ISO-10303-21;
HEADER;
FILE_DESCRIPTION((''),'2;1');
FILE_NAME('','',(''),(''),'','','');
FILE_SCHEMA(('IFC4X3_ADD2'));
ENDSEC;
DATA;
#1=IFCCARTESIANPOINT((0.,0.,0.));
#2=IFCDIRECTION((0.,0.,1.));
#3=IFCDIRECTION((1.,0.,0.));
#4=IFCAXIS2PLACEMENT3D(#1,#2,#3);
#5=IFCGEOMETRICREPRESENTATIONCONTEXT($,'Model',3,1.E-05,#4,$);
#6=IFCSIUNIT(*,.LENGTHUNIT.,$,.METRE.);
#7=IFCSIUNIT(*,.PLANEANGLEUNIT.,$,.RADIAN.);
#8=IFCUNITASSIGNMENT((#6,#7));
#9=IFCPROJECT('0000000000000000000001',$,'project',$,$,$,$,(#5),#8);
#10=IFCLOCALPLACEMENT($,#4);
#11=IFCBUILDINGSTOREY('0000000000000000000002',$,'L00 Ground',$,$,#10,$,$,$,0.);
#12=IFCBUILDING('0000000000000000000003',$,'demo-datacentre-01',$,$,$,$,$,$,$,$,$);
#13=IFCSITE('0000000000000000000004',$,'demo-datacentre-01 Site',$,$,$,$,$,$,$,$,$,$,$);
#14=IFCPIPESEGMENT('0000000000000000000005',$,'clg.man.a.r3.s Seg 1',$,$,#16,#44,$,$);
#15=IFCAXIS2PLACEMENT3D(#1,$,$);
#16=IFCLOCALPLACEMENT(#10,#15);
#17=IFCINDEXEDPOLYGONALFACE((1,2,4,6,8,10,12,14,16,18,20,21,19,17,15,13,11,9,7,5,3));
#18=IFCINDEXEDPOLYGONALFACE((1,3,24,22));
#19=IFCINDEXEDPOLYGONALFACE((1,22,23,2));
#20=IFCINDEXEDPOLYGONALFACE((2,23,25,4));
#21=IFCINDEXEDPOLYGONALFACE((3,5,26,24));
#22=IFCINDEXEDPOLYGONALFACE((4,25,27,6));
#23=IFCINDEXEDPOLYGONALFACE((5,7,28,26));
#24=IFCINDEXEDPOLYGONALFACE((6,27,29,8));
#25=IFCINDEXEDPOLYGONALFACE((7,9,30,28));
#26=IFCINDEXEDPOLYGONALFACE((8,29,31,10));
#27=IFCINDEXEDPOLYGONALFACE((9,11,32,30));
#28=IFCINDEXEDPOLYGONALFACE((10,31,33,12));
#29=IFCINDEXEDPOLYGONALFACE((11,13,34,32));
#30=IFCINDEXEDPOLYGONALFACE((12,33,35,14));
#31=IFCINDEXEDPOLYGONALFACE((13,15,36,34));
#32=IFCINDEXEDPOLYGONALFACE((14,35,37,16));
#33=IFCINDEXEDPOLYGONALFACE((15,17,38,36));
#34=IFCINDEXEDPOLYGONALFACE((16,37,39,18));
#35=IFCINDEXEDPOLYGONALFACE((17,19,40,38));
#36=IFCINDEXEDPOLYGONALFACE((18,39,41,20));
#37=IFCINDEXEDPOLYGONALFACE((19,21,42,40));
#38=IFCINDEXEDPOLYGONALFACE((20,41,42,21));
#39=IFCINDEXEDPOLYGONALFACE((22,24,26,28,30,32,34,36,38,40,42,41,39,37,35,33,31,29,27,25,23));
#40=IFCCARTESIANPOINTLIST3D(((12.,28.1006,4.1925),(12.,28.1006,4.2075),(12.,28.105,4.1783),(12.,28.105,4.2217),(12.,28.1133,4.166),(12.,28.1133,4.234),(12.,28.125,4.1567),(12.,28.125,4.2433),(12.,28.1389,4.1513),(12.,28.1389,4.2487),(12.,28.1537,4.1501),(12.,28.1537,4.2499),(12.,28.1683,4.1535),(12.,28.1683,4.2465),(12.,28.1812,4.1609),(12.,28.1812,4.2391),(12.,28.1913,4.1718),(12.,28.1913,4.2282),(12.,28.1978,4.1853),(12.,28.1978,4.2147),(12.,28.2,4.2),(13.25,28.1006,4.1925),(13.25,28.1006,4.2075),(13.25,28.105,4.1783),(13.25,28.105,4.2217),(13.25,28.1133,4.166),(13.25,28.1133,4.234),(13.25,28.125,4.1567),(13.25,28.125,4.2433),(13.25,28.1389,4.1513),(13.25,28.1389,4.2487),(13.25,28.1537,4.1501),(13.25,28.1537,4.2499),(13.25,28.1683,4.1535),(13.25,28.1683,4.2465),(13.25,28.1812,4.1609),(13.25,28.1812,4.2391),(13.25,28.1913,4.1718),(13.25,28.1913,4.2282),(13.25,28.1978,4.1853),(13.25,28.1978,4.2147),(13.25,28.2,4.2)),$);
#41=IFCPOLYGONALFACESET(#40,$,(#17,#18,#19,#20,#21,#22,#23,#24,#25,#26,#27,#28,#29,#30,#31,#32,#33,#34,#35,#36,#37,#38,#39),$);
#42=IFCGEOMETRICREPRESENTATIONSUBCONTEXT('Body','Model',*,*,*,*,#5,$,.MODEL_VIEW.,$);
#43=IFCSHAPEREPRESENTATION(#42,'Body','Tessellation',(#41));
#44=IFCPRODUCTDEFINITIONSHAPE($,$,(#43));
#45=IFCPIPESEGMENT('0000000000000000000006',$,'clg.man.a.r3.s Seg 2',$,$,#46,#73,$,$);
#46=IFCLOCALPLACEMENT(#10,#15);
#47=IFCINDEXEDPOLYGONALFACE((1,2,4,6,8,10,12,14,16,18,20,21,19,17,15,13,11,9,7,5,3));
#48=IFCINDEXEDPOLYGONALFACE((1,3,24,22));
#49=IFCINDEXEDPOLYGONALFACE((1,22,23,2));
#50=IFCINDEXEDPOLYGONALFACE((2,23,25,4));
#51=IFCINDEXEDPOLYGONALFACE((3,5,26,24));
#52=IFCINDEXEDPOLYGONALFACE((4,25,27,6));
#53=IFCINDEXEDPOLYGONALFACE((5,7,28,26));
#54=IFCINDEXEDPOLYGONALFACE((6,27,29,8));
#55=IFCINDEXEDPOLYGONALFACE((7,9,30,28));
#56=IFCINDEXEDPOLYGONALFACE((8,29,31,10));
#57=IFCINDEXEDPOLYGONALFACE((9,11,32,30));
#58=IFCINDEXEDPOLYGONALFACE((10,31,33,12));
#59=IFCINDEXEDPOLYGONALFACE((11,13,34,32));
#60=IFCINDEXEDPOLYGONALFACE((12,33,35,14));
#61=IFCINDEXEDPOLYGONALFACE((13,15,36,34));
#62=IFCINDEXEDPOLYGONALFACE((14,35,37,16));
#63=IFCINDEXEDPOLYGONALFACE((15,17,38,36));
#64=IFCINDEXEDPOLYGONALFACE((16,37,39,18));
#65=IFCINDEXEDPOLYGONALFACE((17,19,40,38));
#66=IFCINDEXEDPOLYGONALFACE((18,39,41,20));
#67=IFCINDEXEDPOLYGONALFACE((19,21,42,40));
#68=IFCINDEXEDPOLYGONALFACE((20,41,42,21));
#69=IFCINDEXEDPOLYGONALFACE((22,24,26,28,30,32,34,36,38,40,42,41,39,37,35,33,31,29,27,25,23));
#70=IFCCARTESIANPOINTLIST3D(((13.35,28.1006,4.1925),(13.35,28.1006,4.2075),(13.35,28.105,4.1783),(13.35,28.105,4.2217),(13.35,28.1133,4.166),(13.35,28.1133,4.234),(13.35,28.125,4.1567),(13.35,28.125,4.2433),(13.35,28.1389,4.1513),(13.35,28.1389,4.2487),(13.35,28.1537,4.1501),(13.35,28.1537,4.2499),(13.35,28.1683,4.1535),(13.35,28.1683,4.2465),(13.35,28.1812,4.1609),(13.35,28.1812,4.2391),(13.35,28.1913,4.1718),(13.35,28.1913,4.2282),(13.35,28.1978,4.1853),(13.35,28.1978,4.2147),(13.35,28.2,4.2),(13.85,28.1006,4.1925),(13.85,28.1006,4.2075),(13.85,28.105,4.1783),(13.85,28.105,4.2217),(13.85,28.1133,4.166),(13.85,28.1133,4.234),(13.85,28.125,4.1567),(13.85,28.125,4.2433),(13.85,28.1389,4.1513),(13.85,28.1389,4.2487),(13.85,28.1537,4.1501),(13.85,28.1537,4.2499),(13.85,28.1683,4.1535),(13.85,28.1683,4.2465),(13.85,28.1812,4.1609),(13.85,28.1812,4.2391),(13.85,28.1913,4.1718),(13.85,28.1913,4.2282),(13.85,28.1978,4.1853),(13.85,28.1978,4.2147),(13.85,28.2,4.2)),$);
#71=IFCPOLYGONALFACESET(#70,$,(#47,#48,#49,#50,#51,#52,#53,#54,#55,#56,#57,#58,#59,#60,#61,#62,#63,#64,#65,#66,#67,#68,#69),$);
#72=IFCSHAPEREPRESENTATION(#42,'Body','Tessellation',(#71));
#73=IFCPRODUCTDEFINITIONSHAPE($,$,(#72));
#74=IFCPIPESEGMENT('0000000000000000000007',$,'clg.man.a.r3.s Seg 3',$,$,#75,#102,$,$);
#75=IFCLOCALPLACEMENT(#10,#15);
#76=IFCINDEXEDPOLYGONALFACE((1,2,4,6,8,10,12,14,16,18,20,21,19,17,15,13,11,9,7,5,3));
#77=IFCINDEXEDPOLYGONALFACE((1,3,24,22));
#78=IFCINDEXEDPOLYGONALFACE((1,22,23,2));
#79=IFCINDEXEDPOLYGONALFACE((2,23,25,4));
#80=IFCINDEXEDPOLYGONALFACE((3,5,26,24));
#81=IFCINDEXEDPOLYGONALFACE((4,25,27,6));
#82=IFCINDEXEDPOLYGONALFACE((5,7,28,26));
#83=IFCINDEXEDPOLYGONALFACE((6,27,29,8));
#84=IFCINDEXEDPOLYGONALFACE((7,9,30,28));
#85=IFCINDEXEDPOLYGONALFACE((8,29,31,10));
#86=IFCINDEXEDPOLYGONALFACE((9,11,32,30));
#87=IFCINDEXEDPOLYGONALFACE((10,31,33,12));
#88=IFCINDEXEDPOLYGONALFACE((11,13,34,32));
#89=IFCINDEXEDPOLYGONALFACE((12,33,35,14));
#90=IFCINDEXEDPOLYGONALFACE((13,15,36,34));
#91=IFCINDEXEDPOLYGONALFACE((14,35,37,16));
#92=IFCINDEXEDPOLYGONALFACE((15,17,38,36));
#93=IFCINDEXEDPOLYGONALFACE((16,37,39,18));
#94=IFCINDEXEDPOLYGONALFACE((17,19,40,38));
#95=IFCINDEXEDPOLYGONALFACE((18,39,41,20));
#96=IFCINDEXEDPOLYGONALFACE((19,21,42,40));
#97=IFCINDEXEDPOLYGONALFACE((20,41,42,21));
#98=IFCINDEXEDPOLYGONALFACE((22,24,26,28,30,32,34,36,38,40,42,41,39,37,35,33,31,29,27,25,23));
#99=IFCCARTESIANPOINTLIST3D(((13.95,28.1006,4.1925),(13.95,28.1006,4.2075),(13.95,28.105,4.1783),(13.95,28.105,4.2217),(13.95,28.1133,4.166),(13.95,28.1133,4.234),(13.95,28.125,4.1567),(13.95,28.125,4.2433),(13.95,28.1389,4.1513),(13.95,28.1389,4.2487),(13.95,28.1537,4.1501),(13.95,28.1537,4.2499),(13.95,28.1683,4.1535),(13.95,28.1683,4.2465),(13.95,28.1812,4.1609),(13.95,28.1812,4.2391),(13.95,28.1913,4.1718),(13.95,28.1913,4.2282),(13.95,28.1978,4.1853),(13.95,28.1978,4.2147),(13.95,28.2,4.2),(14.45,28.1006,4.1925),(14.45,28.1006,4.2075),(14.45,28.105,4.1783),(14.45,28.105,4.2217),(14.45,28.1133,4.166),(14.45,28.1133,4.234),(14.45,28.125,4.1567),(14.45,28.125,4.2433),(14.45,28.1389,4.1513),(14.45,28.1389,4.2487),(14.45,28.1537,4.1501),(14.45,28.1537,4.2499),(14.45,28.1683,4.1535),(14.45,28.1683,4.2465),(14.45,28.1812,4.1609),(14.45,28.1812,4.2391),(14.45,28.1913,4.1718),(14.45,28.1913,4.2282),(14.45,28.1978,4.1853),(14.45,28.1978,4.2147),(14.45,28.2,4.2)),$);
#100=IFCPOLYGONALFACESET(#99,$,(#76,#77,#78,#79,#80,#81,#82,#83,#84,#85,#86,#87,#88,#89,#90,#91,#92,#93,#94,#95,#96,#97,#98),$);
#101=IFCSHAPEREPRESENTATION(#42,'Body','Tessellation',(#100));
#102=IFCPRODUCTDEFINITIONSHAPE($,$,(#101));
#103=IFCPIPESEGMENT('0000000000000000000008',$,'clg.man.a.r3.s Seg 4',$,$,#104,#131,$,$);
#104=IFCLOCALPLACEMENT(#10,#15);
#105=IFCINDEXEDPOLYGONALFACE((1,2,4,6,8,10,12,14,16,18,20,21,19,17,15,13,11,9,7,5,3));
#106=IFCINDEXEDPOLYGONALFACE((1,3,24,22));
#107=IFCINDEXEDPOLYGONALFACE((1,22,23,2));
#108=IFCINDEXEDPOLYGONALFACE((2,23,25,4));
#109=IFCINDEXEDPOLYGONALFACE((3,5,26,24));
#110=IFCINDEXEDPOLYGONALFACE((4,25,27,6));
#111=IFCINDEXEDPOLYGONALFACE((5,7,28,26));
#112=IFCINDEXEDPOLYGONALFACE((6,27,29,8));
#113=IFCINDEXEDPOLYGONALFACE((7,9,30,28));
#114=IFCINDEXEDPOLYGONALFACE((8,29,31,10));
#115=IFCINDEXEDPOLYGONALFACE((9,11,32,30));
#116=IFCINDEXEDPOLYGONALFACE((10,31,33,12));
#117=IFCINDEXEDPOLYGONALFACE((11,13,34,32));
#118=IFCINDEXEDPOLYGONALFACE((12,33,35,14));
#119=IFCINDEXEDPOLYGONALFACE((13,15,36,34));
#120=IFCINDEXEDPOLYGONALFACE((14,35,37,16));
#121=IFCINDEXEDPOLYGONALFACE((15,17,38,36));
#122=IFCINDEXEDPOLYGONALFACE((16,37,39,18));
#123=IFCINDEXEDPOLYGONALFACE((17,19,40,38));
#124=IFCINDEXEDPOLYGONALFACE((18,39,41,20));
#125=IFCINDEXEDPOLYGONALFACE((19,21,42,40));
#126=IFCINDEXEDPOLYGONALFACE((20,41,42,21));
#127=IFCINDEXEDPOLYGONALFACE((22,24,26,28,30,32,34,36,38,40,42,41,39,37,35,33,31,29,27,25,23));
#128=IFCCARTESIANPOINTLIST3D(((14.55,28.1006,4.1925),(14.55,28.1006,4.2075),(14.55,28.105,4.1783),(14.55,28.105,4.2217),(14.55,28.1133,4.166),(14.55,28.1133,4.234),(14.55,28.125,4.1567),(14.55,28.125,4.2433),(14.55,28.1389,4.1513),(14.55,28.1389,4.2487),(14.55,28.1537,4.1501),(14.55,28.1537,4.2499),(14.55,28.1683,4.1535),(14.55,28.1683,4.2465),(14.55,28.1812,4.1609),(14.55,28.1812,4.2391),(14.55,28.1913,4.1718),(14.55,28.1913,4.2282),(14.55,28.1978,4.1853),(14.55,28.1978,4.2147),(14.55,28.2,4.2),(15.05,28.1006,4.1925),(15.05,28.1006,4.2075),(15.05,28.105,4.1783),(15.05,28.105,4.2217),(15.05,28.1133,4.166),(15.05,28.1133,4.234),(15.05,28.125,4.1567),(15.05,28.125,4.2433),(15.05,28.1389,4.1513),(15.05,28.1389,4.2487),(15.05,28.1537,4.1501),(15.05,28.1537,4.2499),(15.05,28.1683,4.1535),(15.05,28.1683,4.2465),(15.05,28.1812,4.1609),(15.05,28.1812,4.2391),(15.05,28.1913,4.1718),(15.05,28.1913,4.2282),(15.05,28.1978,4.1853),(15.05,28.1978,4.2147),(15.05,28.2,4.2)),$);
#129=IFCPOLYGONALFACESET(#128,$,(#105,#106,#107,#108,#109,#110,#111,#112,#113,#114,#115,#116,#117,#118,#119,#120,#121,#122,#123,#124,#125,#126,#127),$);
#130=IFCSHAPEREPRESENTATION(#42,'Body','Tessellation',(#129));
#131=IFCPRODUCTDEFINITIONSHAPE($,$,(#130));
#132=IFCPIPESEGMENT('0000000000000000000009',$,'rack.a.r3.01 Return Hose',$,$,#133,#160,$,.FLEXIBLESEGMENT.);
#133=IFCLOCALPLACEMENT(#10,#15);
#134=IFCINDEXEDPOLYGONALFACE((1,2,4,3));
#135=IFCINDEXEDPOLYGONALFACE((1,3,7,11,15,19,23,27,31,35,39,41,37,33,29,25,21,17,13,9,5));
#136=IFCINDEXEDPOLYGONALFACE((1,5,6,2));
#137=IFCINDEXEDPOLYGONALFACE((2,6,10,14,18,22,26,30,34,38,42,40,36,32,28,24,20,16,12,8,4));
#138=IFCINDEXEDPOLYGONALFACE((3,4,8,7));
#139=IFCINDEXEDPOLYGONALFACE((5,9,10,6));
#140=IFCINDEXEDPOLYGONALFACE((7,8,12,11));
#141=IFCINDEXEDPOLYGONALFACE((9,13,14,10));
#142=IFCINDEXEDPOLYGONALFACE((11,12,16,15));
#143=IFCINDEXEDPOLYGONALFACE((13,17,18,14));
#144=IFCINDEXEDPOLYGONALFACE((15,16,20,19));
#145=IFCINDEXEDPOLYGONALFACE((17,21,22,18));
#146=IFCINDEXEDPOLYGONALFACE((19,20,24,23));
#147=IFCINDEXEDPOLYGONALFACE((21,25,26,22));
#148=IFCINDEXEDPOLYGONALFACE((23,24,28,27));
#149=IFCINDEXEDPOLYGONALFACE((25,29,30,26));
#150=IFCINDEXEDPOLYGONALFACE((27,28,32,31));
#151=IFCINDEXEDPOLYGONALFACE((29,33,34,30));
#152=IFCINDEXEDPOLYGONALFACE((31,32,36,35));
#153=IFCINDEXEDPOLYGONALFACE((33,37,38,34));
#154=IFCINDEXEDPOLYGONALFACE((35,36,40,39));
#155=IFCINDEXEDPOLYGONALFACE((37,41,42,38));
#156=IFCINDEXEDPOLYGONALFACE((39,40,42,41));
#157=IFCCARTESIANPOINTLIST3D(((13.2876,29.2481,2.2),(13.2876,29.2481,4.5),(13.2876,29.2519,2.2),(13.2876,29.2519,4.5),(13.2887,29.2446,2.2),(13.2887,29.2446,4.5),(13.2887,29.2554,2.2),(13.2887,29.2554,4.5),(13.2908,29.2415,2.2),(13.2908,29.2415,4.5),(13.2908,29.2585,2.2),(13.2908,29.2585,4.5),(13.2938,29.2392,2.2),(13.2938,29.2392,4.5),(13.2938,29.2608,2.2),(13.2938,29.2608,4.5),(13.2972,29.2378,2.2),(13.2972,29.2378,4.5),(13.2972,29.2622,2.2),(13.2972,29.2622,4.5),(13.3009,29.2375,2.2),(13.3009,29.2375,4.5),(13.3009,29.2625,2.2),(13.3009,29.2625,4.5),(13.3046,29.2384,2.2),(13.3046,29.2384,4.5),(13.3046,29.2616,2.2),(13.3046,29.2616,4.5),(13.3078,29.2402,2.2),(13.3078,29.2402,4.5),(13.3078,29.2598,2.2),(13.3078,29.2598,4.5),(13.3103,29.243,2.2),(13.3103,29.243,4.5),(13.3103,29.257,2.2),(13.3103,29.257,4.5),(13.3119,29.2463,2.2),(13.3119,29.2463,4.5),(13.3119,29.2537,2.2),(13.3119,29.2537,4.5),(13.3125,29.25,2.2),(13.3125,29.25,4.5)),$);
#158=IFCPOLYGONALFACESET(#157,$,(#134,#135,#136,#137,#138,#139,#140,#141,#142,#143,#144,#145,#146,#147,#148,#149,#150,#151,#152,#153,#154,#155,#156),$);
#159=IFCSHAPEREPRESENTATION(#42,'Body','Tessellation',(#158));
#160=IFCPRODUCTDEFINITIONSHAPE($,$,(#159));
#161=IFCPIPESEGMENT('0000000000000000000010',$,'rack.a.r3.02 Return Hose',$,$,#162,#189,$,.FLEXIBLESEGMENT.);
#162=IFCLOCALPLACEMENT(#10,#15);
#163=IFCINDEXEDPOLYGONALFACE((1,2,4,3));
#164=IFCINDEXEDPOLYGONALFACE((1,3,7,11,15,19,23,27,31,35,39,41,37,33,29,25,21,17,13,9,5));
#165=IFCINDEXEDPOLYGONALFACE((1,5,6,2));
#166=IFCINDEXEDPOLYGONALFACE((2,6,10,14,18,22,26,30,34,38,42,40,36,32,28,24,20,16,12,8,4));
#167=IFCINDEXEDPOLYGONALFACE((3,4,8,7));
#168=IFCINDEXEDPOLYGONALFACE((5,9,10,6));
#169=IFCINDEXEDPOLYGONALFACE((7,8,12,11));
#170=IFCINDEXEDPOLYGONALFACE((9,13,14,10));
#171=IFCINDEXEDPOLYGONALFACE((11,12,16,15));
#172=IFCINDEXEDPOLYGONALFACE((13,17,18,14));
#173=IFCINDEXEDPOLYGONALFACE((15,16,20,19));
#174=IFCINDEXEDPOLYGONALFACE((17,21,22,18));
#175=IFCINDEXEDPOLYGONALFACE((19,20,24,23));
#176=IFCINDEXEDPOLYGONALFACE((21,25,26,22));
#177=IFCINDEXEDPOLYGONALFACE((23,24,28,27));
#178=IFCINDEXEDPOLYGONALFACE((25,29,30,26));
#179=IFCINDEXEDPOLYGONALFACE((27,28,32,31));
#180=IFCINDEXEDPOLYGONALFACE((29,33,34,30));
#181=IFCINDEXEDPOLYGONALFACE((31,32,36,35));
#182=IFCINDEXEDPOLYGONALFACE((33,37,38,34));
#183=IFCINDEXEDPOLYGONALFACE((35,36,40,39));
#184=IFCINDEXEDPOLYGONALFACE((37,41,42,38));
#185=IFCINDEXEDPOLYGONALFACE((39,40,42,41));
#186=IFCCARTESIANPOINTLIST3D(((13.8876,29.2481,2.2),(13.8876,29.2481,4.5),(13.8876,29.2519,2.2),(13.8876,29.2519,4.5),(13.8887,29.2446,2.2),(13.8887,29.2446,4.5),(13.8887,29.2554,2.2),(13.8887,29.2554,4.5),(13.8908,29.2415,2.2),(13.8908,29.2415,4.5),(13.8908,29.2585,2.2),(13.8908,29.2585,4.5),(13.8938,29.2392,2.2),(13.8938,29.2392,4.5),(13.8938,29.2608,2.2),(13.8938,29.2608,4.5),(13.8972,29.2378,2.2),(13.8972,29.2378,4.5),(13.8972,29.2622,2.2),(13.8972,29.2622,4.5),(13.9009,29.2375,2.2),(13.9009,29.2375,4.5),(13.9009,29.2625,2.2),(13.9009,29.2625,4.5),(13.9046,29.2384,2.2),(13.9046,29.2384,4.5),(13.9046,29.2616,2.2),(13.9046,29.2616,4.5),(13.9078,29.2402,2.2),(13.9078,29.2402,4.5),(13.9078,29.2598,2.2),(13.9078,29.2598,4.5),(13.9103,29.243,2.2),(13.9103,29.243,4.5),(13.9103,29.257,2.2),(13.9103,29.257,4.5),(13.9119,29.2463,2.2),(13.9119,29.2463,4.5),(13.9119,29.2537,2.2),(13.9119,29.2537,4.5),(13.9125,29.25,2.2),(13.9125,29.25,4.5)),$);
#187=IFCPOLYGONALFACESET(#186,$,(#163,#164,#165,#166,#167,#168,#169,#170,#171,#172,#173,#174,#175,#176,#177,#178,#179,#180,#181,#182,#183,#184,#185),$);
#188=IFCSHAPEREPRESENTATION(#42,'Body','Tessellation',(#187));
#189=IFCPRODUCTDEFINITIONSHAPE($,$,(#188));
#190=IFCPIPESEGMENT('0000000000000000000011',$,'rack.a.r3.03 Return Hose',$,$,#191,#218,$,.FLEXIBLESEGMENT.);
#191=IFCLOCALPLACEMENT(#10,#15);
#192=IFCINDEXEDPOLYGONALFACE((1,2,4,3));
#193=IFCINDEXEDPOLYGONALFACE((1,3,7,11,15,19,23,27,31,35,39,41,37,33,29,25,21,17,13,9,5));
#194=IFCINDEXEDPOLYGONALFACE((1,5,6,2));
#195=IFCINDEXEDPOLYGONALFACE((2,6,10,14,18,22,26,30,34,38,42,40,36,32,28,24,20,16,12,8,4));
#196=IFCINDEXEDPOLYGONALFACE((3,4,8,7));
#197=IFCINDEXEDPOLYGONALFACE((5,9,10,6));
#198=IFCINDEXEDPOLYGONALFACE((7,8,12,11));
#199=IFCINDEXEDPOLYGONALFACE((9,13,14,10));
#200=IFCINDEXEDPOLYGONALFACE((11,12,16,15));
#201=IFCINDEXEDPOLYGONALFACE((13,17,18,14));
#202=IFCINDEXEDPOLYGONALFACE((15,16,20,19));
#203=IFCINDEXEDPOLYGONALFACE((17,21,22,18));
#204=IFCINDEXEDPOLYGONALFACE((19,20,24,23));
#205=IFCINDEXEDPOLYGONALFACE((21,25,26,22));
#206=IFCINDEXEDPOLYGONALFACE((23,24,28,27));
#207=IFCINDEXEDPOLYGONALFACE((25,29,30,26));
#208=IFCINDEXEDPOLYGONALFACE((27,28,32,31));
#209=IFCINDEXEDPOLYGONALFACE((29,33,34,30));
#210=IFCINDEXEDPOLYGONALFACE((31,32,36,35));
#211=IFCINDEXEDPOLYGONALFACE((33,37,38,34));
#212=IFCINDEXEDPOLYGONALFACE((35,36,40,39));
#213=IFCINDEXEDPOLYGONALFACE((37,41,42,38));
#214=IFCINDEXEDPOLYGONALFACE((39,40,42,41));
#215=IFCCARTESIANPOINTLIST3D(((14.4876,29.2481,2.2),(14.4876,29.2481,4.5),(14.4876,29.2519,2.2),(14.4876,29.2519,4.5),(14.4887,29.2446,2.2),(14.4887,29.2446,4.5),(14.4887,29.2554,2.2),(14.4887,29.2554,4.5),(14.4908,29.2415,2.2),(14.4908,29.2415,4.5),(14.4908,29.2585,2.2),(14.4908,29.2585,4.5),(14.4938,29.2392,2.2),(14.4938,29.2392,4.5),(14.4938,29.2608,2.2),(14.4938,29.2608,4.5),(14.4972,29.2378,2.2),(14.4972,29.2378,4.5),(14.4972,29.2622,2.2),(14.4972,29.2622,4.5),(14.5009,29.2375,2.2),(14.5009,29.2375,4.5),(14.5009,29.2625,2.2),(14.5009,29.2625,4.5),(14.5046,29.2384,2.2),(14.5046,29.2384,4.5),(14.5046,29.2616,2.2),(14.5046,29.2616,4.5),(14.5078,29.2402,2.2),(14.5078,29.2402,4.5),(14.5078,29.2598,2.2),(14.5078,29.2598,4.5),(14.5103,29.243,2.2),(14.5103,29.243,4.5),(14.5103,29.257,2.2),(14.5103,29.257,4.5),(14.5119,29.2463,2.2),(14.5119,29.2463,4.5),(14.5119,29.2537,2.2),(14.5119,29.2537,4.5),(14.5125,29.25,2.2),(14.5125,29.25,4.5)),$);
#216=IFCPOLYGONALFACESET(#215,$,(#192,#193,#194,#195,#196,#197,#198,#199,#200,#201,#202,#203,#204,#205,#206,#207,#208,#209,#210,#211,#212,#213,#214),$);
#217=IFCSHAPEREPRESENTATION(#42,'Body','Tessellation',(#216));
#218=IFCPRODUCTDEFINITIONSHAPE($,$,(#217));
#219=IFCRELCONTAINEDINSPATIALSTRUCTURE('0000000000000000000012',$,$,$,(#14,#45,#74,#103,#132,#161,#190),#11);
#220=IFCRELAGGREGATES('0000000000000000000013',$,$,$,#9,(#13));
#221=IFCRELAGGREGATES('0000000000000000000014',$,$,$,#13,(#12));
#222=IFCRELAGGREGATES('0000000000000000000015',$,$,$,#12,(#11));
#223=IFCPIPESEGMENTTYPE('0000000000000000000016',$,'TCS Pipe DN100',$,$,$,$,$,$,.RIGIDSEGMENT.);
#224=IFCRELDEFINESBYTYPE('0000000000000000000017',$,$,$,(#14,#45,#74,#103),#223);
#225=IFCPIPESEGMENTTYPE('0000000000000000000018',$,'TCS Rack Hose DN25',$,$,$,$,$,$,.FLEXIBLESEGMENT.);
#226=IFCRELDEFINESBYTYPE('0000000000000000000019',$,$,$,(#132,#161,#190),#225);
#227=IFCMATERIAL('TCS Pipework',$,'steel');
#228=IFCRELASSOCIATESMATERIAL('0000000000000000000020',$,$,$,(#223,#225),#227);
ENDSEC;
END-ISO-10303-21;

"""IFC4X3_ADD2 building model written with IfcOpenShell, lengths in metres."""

from ifc_helpers import new_model, si_unit, frame, origin_with_axes, place, context, subcontext, project, spatial, circle, extrude, material, type_object, element, save


model = new_model("IFC4X3_ADD2")

# Units and contexts
model_context = context("Model", 3, precision=1e-05, world=origin_with_axes())
body_context = subcontext(model_context, "Body", "Model", "MODEL_VIEW")
ifc_project = project(units=[si_unit("LENGTHUNIT", "METRE"), si_unit("PLANEANGLEUNIT", "RADIAN")], contexts=[model_context])

# Site, building, storey
site = spatial("IfcSite", under=ifc_project, Name="demo-datacentre-01 Site")
building = spatial("IfcBuilding", under=site, Name="demo-datacentre-01")
storey_placement = place(None, origin_with_axes())
storey = spatial("IfcBuildingStorey", under=building, at=storey_placement, Name="L00 Ground", Elevation=0.0)

# Shared definitions
ifc_material = material(Name="TCS Pipework", Category="steel")

# Pipe segments
pipe_segment_type_1 = type_object("IfcPipeSegmentType", Name="TCS Pipe DN100", PredefinedType="RIGIDSEGMENT", material=ifc_material)
pipe_segment_1_placement = place(storey_placement, frame((12.0, 28.15, 4.2), z_axis=(1.0, 0.0, 0.0), x_axis=(0.0, 1.0, 0.0)))
element("IfcPipeSegment", 1, at=pipe_segment_1_placement, inside=storey, type_object=pipe_segment_type_1, Name="clg.man.a.r3.s Seg 1", context=body_context, shape_type="SweptSolid", body=[
    extrude(circle(Radius=0.05), origin_with_axes(), (0.0, 0.0, 1.0), 1.25),
])
for number, where, z_axis, x_axis, name in (
    (2, (13.35, 28.15, 4.2), (1.0, 0.0, 0.0), (0.0, 1.0, 0.0), "clg.man.a.r3.s Seg 2"),
    (3, (13.95, 28.15, 4.2), (1.0, 0.0, 0.0), (0.0, 1.0, 0.0), "clg.man.a.r3.s Seg 3"),
):
    element("IfcPipeSegment", number, at=place(storey_placement, frame(where, z_axis=z_axis, x_axis=x_axis)), inside=storey, type_object=pipe_segment_type_1, Name=name, context=body_context, shape_type="SweptSolid", body=[
        extrude(circle(Radius=0.05), origin_with_axes(), (0.0, 0.0, 1.0), 0.5),
    ])
pipe_segment_2_placement = place(storey_placement, frame((14.55, 28.15, 4.2), z_axis=(1.0, 0.0, 0.0), x_axis=(0.0, 1.0, 0.0)))
element("IfcPipeSegment", 4, at=pipe_segment_2_placement, inside=storey, type_object=pipe_segment_type_1, Name="clg.man.a.r3.s Seg 4", context=body_context, shape_type="SweptSolid", body=[
    extrude(circle(Radius=0.05), origin_with_axes(), (0.0, 0.0, 1.0), 0.5),
])
pipe_segment_type_2 = type_object("IfcPipeSegmentType", Name="TCS Rack Hose DN25", PredefinedType="FLEXIBLESEGMENT", material=ifc_material)
for number, where, z_axis, x_axis, name in (
    (5, (13.3, 29.25, 4.5), (0.0, 0.0, -1.0), (1.0, 0.0, 0.0), "rack.a.r3.01 Return Hose"),
    (6, (13.9, 29.25, 4.5), (0.0, 0.0, -1.0), (1.0, 0.0, 0.0), "rack.a.r3.02 Return Hose"),
    (7, (14.5, 29.25, 4.5), (0.0, 0.0, -1.0), (1.0, 0.0, 0.0), "rack.a.r3.03 Return Hose"),
):
    element("IfcPipeSegment", number, at=place(storey_placement, frame(where, z_axis=z_axis, x_axis=x_axis)), inside=storey, type_object=pipe_segment_type_2, Name=name, PredefinedType="FLEXIBLESEGMENT", context=body_context, shape_type="SweptSolid", body=[
        extrude(circle(Radius=0.0125), origin_with_axes(), (0.0, 0.0, 1.0), 2.3),
    ])

save(model, "model.ifc")
